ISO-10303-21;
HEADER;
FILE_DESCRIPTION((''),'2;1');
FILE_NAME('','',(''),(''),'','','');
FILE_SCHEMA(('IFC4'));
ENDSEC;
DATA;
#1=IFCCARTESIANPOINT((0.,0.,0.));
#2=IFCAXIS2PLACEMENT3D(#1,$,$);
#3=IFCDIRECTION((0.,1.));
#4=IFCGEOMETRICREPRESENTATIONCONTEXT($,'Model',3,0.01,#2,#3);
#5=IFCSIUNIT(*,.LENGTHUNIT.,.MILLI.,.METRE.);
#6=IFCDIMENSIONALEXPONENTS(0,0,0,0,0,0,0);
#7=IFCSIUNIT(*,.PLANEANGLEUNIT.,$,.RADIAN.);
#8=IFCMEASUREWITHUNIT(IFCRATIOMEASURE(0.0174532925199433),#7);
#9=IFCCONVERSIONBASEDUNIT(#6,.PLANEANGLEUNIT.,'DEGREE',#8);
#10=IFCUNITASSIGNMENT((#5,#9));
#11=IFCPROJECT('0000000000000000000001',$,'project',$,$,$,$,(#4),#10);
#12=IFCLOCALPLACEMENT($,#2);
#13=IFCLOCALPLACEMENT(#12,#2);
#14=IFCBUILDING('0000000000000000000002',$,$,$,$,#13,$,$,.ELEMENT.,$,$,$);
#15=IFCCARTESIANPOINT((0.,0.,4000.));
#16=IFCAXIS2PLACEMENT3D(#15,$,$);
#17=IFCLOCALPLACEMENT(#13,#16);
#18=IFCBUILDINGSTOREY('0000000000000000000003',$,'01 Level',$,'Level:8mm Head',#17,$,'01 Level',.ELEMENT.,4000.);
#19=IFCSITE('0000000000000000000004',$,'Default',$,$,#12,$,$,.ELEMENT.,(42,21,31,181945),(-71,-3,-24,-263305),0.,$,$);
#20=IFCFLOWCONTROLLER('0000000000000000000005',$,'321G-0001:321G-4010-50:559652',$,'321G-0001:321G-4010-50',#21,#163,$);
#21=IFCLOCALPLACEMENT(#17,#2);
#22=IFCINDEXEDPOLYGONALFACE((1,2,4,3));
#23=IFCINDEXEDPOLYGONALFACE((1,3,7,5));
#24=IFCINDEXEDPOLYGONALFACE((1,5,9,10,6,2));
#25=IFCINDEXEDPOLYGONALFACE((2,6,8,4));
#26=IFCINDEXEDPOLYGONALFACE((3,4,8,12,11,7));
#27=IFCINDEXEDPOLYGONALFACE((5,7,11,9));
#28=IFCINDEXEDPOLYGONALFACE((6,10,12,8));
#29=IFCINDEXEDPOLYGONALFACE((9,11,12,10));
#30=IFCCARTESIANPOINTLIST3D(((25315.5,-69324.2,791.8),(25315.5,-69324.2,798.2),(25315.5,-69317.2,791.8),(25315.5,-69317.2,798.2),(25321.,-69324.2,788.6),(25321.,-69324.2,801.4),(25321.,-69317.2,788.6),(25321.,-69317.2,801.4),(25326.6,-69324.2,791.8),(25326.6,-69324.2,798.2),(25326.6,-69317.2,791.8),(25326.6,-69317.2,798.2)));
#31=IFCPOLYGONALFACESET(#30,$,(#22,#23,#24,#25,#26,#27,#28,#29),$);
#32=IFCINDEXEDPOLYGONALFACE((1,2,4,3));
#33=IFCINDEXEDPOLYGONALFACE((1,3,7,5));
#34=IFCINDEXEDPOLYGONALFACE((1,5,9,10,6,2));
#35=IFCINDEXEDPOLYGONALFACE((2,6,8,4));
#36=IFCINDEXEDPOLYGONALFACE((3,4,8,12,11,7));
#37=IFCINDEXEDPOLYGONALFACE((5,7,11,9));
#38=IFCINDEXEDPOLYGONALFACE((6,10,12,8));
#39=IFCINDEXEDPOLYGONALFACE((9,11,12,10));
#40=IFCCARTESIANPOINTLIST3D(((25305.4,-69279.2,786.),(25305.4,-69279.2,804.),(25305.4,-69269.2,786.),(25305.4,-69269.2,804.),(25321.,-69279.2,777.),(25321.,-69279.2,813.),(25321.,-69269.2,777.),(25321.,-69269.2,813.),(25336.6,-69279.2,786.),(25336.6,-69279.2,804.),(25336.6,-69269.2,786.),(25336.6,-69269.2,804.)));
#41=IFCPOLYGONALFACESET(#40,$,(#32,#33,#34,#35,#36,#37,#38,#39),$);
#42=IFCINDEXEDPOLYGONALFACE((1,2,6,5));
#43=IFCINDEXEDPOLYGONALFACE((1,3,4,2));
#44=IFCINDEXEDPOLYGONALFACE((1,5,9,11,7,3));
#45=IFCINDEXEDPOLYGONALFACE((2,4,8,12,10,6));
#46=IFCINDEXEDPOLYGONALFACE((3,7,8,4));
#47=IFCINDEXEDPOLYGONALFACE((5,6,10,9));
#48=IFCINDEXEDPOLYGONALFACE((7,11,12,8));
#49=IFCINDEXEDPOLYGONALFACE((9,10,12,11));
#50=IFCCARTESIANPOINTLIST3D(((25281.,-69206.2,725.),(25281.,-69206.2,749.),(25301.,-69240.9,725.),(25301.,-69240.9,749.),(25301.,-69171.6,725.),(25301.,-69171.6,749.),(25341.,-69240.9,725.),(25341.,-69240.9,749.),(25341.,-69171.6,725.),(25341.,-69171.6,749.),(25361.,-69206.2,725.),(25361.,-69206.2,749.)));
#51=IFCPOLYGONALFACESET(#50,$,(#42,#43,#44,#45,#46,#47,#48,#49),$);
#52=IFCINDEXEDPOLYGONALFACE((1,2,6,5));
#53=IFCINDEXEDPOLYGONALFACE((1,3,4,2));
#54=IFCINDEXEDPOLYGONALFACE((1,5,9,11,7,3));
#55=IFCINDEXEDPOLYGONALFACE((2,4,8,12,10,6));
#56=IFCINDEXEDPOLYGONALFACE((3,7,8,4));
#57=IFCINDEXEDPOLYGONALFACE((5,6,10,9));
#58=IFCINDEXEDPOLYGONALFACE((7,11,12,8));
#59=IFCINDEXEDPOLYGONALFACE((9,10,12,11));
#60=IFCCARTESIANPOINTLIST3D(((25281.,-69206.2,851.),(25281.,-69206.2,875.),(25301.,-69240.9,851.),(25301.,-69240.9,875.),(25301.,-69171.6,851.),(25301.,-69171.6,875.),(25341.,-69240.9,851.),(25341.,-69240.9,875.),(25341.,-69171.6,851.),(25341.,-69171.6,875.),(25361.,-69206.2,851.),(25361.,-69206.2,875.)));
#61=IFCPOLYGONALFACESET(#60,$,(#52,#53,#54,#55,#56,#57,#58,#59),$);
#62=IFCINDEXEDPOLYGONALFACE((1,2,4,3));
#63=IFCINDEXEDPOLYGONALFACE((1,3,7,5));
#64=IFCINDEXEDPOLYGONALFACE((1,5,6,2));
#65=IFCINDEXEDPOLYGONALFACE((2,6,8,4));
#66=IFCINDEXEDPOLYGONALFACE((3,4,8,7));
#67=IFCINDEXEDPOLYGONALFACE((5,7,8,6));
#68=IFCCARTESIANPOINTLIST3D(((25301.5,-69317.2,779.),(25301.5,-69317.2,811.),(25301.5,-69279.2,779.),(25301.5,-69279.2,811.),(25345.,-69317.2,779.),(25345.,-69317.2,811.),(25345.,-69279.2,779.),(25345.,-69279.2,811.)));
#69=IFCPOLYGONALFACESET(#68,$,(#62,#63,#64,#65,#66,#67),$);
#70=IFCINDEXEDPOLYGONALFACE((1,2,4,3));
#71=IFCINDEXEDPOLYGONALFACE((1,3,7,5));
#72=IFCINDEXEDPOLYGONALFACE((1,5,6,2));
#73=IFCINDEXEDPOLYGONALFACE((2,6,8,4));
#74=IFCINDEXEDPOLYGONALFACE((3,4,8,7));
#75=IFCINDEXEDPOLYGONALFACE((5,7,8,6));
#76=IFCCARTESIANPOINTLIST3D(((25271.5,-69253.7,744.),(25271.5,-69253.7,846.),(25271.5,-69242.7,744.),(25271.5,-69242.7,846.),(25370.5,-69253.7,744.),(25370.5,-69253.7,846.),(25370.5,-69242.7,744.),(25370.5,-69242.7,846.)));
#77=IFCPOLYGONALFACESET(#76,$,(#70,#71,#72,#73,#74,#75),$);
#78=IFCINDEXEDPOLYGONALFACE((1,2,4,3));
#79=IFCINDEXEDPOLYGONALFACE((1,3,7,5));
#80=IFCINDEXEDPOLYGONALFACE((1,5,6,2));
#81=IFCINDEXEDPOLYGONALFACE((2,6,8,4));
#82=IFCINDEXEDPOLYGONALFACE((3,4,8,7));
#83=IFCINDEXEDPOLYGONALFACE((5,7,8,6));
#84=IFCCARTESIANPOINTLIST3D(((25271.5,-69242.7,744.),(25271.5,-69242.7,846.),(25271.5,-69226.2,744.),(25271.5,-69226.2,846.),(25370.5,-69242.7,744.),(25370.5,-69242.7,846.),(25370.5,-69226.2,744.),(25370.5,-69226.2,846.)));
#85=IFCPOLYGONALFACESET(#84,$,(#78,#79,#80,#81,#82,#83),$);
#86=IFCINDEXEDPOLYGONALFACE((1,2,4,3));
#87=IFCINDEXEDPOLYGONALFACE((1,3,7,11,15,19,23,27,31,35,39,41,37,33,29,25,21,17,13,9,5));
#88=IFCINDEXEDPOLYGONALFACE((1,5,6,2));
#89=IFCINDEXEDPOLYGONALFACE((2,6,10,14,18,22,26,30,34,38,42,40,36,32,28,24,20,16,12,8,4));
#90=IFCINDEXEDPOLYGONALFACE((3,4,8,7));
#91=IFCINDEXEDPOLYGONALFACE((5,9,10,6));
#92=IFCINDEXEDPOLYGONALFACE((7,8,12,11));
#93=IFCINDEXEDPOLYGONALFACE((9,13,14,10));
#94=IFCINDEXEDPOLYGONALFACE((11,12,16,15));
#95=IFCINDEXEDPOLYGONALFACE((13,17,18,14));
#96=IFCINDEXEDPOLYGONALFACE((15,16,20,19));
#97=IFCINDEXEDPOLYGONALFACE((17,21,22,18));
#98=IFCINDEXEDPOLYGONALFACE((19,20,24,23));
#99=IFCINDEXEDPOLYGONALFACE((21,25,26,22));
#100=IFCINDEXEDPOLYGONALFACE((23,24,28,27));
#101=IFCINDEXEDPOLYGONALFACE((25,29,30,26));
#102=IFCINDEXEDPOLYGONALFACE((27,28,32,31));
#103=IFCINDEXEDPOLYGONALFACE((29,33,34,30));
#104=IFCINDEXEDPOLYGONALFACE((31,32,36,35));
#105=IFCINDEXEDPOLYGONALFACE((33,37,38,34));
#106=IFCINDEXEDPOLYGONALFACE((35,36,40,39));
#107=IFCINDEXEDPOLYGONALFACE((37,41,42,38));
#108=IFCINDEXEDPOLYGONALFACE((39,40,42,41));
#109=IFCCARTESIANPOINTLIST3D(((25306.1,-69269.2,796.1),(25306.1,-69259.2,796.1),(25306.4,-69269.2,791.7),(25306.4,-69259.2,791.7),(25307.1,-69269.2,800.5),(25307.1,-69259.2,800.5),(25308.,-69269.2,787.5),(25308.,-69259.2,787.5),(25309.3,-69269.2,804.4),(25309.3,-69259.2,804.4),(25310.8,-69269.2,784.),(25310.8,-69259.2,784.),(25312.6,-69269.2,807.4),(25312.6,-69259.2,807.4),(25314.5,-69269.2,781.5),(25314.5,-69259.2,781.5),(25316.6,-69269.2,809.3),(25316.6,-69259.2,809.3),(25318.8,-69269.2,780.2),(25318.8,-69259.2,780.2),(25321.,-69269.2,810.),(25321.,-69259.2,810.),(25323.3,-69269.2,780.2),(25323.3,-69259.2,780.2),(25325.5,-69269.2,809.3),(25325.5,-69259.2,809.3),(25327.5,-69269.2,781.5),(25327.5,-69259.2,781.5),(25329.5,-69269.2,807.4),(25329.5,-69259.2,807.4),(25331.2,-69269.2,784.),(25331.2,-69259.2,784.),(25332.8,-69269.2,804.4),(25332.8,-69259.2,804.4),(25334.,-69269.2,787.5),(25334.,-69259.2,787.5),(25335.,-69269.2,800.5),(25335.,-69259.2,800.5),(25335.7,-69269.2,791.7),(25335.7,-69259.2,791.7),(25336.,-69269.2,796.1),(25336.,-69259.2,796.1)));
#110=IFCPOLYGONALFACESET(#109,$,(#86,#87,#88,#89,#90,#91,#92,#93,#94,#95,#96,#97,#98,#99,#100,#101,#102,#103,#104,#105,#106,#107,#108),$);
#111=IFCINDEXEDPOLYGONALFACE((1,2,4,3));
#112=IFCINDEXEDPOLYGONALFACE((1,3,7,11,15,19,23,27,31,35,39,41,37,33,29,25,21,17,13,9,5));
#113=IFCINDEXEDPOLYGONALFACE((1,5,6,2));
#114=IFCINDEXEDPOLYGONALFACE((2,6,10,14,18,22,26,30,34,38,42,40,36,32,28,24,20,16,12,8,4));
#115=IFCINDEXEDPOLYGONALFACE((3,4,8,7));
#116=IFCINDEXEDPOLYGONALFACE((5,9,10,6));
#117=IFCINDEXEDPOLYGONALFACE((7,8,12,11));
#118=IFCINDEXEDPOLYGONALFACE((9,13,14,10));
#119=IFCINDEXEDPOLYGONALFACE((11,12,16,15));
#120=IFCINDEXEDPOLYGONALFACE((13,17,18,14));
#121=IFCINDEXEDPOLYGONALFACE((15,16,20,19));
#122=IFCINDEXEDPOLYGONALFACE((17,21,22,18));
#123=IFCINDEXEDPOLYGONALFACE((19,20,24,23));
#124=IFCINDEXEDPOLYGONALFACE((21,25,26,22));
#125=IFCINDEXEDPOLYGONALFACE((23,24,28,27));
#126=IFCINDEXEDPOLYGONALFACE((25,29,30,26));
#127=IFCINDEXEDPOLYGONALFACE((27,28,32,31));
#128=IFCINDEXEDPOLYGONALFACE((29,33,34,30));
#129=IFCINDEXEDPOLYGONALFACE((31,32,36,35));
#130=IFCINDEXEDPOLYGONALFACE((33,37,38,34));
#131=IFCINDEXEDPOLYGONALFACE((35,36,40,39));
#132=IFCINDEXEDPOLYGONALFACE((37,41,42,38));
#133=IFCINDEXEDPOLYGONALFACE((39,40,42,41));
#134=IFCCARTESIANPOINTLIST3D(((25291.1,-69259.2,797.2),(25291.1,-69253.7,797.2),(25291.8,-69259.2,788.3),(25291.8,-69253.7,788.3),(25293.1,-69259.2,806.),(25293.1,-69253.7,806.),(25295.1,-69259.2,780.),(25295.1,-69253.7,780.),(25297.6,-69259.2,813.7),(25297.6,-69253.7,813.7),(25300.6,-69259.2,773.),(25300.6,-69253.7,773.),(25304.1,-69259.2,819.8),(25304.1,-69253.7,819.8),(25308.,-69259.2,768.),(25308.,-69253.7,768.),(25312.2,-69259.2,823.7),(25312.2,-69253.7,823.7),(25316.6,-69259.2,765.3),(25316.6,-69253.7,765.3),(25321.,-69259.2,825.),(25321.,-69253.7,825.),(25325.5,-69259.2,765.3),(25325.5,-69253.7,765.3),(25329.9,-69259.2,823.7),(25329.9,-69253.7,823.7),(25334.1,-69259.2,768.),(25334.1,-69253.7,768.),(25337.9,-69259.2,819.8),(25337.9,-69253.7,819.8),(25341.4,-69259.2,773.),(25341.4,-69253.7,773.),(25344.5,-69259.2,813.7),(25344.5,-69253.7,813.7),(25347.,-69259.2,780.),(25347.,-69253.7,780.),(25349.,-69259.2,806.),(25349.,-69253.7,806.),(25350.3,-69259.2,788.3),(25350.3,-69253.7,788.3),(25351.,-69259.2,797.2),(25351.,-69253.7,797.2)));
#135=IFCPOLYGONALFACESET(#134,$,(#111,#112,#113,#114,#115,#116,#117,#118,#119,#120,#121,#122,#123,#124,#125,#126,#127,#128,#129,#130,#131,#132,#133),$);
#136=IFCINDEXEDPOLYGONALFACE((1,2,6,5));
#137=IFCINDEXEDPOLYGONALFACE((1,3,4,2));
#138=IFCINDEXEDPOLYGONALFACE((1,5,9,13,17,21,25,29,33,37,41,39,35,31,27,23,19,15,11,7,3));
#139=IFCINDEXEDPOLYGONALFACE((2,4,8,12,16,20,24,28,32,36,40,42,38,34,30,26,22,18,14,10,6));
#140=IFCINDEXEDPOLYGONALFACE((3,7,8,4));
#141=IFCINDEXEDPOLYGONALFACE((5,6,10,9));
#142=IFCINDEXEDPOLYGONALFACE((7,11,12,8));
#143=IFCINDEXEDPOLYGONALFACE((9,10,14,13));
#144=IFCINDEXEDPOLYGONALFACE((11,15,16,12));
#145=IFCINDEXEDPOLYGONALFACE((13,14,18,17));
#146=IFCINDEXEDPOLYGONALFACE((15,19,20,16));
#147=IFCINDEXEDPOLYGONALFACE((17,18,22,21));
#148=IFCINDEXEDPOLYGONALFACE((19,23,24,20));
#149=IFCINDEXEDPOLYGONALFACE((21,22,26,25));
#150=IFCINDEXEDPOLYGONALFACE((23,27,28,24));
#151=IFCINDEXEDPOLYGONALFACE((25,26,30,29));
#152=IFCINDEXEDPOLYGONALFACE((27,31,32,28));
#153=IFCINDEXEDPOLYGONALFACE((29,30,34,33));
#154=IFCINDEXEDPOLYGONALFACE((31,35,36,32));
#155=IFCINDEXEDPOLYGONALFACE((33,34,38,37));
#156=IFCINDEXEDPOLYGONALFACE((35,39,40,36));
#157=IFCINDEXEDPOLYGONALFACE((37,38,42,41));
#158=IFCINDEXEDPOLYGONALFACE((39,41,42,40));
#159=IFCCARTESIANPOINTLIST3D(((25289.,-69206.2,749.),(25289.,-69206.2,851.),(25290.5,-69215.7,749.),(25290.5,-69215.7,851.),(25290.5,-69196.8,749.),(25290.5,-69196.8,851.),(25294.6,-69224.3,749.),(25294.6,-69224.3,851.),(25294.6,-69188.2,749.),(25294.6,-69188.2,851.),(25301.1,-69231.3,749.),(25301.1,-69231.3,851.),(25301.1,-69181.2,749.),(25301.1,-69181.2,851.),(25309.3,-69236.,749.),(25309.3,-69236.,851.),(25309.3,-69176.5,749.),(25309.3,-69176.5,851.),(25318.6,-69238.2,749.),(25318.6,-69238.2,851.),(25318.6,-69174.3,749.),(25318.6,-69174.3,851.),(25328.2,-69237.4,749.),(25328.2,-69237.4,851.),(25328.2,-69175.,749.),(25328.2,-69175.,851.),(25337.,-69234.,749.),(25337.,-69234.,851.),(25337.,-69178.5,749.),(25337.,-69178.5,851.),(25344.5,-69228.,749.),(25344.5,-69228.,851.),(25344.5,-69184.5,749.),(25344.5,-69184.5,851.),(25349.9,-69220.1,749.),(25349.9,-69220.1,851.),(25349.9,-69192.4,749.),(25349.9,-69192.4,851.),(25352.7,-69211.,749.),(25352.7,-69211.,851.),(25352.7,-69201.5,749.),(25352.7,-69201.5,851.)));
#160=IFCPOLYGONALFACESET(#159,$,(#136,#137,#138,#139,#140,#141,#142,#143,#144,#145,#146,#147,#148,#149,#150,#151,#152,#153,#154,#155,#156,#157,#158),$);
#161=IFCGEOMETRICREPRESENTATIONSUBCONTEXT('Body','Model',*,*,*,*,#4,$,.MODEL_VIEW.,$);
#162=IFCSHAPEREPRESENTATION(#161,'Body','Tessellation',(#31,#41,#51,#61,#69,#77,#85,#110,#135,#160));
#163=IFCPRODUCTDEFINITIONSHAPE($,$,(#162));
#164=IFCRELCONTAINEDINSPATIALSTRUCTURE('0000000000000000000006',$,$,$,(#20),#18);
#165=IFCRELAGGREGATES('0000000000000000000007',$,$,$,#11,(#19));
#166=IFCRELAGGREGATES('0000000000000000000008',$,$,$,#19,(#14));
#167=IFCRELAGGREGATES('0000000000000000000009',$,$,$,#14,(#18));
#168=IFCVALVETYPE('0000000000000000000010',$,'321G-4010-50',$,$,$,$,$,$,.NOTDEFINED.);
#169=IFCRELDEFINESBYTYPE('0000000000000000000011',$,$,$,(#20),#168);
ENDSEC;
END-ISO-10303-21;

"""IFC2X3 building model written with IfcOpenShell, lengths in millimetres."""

from ifc_helpers import new_model, entity, si_unit, converted_unit, direction, frame, frame_2d, origin, origin_2d_with_axis, place, context, subcontext, project, spatial, polyline, rectangle, circle, outline, extrude, source, transform, mapped, type_object, type_shapes, element, save


model = new_model("IFC2X3")

# Units and contexts
model_context = context("Model", 3, precision=0.01, world=origin(), true_north=direction((0.0, 1.0)))
body_context = subcontext(model_context, "Body", "Model", "MODEL_VIEW")
ifc_project = project(units=[si_unit("LENGTHUNIT", "METRE", prefix="MILLI"), converted_unit("PLANEANGLEUNIT", "DEGREE", entity("IfcRatioMeasure", 0.0174532925199433), si_unit("PLANEANGLEUNIT", "RADIAN"), dimensions=[0, 0, 0, 0, 0, 0, 0])], contexts=[model_context])

# Site, building, storey
site_placement = place(None, origin())
site = spatial("IfcSite", under=ifc_project, at=site_placement, Name="Default", CompositionType="ELEMENT", RefLatitude=(42, 21, 31, 181945), RefLongitude=(-71, -3, -24, -263305), RefElevation=0.0)
building_placement = place(site_placement, origin())
building = spatial("IfcBuilding", under=site, at=building_placement, CompositionType="ELEMENT")
storey_placement = place(building_placement, frame((0.0, 0.0, 4000.0)))
storey = spatial("IfcBuildingStorey", under=building, at=storey_placement, Name="01 Level", ObjectType="Level:8mm Head", LongName="01 Level", CompositionType="ELEMENT", Elevation=4000.0)

# Flow controller
valve_type_1 = type_object("IfcValveType", Name="321G-4010-50", PredefinedType="NOTDEFINED")
shared_shape_1 = source(origin(), body_context, "Body", "SweptSolid", [
    extrude(outline(polyline([(-3.2, -5.5), (3.2, -5.5), (6.4, 0.0), (3.2, 5.5), (-3.2, 5.5), (-6.4, 0.0), (-3.2, -5.5)])), frame((-5.0, 0.0, 111.0), z_axis=(0.0, 0.0, 1.0), x_axis=(-1.0, 0.0, 0.0)), (0.0, 0.0, 1.0), 7.0),
    extrude(outline(polyline([(-9.0, -15.6), (9.0, -15.6), (18.0, 0.0), (9.0, 15.6), (-9.0, 15.6), (-18.0, 0.0), (-9.0, -15.6)])), frame((-5.0, 0.0, 63.0), z_axis=(0.0, 0.0, 1.0), x_axis=(-1.0, 0.0, 0.0)), (0.0, 0.0, 1.0), 10.0),
    extrude(outline(polyline([(-20.0, -34.6), (20.0, -34.6), (40.0, 0.0), (20.0, 34.6), (-20.0, 34.6), (-40.0, 0.0), (-20.0, -34.6)])), frame((-75.0, 0.0, 0.0), z_axis=(1.0, 0.0, 0.0), x_axis=(0.0, -1.0, 0.0)), (0.0, 0.0, 1.0), 24.0),
    extrude(outline(polyline([(-20.0, -34.6), (20.0, -34.6), (40.0, 0.0), (20.0, 34.6), (-20.0, 34.6), (-40.0, 0.0), (-20.0, -34.6)])), frame((51.0, 0.0, 0.0), z_axis=(1.0, 0.0, 0.0), x_axis=(0.0, -1.0, 0.0)), (0.0, 0.0, 1.0), 24.0),
    extrude(rectangle(XDim=32.0, YDim=43.5, at=origin_2d_with_axis()), frame((-5.0, -2.2, 73.0)), (0.0, 0.0, 1.0), 38.0),
    extrude(rectangle(XDim=102.0, YDim=99.0, at=origin_2d_with_axis()), frame((-5.0, 0.0, 36.5)), (0.0, 0.0, 1.0), 11.0),
    extrude(rectangle(XDim=102.0, YDim=99.0, at=origin_2d_with_axis()), frame((-5.0, 0.0, 20.0)), (0.0, 0.0, 1.0), 16.5),
    extrude(circle(Radius=15.0, at=frame_2d((0.0, 0.0), x_axis=(1.0, 0.0))), frame((-5.0, 0.0, 53.0)), (0.0, 0.0, 1.0), 10.0),
    extrude(circle(Radius=30.0, at=frame_2d((0.0, 0.0), x_axis=(1.0, 0.0))), frame((-5.0, 0.0, 47.5)), (0.0, 0.0, 1.0), 5.5),
    extrude(circle(Radius=32.0, at=frame_2d((0.0, 0.0), x_axis=(1.0, 0.0))), frame((-51.0, 0.0, 0.0), z_axis=(1.0, 0.0, 0.0), x_axis=(0.0, 1.0, 0.0)), (0.0, 0.0, 1.0), 102.0),
])
type_shapes(valve_type_1, [shared_shape_1])
flow_controller_1_placement = place(storey_placement, frame((25321.0, -69206.2, 800.0), z_axis=(0.0, -1.0, 0.0), x_axis=(0.0, 0.0, 1.0)))
element("IfcFlowController", 1, at=flow_controller_1_placement, inside=storey, type_object=valve_type_1, Name="321G-0001:321G-4010-50:559652", ObjectType="321G-0001:321G-4010-50", context=body_context, shape_type="MappedRepresentation", body=[
    mapped(shared_shape_1, transform((0.0, 0.0, 0.0), scale=1.0)),
])

save(model, "model.ifc")
